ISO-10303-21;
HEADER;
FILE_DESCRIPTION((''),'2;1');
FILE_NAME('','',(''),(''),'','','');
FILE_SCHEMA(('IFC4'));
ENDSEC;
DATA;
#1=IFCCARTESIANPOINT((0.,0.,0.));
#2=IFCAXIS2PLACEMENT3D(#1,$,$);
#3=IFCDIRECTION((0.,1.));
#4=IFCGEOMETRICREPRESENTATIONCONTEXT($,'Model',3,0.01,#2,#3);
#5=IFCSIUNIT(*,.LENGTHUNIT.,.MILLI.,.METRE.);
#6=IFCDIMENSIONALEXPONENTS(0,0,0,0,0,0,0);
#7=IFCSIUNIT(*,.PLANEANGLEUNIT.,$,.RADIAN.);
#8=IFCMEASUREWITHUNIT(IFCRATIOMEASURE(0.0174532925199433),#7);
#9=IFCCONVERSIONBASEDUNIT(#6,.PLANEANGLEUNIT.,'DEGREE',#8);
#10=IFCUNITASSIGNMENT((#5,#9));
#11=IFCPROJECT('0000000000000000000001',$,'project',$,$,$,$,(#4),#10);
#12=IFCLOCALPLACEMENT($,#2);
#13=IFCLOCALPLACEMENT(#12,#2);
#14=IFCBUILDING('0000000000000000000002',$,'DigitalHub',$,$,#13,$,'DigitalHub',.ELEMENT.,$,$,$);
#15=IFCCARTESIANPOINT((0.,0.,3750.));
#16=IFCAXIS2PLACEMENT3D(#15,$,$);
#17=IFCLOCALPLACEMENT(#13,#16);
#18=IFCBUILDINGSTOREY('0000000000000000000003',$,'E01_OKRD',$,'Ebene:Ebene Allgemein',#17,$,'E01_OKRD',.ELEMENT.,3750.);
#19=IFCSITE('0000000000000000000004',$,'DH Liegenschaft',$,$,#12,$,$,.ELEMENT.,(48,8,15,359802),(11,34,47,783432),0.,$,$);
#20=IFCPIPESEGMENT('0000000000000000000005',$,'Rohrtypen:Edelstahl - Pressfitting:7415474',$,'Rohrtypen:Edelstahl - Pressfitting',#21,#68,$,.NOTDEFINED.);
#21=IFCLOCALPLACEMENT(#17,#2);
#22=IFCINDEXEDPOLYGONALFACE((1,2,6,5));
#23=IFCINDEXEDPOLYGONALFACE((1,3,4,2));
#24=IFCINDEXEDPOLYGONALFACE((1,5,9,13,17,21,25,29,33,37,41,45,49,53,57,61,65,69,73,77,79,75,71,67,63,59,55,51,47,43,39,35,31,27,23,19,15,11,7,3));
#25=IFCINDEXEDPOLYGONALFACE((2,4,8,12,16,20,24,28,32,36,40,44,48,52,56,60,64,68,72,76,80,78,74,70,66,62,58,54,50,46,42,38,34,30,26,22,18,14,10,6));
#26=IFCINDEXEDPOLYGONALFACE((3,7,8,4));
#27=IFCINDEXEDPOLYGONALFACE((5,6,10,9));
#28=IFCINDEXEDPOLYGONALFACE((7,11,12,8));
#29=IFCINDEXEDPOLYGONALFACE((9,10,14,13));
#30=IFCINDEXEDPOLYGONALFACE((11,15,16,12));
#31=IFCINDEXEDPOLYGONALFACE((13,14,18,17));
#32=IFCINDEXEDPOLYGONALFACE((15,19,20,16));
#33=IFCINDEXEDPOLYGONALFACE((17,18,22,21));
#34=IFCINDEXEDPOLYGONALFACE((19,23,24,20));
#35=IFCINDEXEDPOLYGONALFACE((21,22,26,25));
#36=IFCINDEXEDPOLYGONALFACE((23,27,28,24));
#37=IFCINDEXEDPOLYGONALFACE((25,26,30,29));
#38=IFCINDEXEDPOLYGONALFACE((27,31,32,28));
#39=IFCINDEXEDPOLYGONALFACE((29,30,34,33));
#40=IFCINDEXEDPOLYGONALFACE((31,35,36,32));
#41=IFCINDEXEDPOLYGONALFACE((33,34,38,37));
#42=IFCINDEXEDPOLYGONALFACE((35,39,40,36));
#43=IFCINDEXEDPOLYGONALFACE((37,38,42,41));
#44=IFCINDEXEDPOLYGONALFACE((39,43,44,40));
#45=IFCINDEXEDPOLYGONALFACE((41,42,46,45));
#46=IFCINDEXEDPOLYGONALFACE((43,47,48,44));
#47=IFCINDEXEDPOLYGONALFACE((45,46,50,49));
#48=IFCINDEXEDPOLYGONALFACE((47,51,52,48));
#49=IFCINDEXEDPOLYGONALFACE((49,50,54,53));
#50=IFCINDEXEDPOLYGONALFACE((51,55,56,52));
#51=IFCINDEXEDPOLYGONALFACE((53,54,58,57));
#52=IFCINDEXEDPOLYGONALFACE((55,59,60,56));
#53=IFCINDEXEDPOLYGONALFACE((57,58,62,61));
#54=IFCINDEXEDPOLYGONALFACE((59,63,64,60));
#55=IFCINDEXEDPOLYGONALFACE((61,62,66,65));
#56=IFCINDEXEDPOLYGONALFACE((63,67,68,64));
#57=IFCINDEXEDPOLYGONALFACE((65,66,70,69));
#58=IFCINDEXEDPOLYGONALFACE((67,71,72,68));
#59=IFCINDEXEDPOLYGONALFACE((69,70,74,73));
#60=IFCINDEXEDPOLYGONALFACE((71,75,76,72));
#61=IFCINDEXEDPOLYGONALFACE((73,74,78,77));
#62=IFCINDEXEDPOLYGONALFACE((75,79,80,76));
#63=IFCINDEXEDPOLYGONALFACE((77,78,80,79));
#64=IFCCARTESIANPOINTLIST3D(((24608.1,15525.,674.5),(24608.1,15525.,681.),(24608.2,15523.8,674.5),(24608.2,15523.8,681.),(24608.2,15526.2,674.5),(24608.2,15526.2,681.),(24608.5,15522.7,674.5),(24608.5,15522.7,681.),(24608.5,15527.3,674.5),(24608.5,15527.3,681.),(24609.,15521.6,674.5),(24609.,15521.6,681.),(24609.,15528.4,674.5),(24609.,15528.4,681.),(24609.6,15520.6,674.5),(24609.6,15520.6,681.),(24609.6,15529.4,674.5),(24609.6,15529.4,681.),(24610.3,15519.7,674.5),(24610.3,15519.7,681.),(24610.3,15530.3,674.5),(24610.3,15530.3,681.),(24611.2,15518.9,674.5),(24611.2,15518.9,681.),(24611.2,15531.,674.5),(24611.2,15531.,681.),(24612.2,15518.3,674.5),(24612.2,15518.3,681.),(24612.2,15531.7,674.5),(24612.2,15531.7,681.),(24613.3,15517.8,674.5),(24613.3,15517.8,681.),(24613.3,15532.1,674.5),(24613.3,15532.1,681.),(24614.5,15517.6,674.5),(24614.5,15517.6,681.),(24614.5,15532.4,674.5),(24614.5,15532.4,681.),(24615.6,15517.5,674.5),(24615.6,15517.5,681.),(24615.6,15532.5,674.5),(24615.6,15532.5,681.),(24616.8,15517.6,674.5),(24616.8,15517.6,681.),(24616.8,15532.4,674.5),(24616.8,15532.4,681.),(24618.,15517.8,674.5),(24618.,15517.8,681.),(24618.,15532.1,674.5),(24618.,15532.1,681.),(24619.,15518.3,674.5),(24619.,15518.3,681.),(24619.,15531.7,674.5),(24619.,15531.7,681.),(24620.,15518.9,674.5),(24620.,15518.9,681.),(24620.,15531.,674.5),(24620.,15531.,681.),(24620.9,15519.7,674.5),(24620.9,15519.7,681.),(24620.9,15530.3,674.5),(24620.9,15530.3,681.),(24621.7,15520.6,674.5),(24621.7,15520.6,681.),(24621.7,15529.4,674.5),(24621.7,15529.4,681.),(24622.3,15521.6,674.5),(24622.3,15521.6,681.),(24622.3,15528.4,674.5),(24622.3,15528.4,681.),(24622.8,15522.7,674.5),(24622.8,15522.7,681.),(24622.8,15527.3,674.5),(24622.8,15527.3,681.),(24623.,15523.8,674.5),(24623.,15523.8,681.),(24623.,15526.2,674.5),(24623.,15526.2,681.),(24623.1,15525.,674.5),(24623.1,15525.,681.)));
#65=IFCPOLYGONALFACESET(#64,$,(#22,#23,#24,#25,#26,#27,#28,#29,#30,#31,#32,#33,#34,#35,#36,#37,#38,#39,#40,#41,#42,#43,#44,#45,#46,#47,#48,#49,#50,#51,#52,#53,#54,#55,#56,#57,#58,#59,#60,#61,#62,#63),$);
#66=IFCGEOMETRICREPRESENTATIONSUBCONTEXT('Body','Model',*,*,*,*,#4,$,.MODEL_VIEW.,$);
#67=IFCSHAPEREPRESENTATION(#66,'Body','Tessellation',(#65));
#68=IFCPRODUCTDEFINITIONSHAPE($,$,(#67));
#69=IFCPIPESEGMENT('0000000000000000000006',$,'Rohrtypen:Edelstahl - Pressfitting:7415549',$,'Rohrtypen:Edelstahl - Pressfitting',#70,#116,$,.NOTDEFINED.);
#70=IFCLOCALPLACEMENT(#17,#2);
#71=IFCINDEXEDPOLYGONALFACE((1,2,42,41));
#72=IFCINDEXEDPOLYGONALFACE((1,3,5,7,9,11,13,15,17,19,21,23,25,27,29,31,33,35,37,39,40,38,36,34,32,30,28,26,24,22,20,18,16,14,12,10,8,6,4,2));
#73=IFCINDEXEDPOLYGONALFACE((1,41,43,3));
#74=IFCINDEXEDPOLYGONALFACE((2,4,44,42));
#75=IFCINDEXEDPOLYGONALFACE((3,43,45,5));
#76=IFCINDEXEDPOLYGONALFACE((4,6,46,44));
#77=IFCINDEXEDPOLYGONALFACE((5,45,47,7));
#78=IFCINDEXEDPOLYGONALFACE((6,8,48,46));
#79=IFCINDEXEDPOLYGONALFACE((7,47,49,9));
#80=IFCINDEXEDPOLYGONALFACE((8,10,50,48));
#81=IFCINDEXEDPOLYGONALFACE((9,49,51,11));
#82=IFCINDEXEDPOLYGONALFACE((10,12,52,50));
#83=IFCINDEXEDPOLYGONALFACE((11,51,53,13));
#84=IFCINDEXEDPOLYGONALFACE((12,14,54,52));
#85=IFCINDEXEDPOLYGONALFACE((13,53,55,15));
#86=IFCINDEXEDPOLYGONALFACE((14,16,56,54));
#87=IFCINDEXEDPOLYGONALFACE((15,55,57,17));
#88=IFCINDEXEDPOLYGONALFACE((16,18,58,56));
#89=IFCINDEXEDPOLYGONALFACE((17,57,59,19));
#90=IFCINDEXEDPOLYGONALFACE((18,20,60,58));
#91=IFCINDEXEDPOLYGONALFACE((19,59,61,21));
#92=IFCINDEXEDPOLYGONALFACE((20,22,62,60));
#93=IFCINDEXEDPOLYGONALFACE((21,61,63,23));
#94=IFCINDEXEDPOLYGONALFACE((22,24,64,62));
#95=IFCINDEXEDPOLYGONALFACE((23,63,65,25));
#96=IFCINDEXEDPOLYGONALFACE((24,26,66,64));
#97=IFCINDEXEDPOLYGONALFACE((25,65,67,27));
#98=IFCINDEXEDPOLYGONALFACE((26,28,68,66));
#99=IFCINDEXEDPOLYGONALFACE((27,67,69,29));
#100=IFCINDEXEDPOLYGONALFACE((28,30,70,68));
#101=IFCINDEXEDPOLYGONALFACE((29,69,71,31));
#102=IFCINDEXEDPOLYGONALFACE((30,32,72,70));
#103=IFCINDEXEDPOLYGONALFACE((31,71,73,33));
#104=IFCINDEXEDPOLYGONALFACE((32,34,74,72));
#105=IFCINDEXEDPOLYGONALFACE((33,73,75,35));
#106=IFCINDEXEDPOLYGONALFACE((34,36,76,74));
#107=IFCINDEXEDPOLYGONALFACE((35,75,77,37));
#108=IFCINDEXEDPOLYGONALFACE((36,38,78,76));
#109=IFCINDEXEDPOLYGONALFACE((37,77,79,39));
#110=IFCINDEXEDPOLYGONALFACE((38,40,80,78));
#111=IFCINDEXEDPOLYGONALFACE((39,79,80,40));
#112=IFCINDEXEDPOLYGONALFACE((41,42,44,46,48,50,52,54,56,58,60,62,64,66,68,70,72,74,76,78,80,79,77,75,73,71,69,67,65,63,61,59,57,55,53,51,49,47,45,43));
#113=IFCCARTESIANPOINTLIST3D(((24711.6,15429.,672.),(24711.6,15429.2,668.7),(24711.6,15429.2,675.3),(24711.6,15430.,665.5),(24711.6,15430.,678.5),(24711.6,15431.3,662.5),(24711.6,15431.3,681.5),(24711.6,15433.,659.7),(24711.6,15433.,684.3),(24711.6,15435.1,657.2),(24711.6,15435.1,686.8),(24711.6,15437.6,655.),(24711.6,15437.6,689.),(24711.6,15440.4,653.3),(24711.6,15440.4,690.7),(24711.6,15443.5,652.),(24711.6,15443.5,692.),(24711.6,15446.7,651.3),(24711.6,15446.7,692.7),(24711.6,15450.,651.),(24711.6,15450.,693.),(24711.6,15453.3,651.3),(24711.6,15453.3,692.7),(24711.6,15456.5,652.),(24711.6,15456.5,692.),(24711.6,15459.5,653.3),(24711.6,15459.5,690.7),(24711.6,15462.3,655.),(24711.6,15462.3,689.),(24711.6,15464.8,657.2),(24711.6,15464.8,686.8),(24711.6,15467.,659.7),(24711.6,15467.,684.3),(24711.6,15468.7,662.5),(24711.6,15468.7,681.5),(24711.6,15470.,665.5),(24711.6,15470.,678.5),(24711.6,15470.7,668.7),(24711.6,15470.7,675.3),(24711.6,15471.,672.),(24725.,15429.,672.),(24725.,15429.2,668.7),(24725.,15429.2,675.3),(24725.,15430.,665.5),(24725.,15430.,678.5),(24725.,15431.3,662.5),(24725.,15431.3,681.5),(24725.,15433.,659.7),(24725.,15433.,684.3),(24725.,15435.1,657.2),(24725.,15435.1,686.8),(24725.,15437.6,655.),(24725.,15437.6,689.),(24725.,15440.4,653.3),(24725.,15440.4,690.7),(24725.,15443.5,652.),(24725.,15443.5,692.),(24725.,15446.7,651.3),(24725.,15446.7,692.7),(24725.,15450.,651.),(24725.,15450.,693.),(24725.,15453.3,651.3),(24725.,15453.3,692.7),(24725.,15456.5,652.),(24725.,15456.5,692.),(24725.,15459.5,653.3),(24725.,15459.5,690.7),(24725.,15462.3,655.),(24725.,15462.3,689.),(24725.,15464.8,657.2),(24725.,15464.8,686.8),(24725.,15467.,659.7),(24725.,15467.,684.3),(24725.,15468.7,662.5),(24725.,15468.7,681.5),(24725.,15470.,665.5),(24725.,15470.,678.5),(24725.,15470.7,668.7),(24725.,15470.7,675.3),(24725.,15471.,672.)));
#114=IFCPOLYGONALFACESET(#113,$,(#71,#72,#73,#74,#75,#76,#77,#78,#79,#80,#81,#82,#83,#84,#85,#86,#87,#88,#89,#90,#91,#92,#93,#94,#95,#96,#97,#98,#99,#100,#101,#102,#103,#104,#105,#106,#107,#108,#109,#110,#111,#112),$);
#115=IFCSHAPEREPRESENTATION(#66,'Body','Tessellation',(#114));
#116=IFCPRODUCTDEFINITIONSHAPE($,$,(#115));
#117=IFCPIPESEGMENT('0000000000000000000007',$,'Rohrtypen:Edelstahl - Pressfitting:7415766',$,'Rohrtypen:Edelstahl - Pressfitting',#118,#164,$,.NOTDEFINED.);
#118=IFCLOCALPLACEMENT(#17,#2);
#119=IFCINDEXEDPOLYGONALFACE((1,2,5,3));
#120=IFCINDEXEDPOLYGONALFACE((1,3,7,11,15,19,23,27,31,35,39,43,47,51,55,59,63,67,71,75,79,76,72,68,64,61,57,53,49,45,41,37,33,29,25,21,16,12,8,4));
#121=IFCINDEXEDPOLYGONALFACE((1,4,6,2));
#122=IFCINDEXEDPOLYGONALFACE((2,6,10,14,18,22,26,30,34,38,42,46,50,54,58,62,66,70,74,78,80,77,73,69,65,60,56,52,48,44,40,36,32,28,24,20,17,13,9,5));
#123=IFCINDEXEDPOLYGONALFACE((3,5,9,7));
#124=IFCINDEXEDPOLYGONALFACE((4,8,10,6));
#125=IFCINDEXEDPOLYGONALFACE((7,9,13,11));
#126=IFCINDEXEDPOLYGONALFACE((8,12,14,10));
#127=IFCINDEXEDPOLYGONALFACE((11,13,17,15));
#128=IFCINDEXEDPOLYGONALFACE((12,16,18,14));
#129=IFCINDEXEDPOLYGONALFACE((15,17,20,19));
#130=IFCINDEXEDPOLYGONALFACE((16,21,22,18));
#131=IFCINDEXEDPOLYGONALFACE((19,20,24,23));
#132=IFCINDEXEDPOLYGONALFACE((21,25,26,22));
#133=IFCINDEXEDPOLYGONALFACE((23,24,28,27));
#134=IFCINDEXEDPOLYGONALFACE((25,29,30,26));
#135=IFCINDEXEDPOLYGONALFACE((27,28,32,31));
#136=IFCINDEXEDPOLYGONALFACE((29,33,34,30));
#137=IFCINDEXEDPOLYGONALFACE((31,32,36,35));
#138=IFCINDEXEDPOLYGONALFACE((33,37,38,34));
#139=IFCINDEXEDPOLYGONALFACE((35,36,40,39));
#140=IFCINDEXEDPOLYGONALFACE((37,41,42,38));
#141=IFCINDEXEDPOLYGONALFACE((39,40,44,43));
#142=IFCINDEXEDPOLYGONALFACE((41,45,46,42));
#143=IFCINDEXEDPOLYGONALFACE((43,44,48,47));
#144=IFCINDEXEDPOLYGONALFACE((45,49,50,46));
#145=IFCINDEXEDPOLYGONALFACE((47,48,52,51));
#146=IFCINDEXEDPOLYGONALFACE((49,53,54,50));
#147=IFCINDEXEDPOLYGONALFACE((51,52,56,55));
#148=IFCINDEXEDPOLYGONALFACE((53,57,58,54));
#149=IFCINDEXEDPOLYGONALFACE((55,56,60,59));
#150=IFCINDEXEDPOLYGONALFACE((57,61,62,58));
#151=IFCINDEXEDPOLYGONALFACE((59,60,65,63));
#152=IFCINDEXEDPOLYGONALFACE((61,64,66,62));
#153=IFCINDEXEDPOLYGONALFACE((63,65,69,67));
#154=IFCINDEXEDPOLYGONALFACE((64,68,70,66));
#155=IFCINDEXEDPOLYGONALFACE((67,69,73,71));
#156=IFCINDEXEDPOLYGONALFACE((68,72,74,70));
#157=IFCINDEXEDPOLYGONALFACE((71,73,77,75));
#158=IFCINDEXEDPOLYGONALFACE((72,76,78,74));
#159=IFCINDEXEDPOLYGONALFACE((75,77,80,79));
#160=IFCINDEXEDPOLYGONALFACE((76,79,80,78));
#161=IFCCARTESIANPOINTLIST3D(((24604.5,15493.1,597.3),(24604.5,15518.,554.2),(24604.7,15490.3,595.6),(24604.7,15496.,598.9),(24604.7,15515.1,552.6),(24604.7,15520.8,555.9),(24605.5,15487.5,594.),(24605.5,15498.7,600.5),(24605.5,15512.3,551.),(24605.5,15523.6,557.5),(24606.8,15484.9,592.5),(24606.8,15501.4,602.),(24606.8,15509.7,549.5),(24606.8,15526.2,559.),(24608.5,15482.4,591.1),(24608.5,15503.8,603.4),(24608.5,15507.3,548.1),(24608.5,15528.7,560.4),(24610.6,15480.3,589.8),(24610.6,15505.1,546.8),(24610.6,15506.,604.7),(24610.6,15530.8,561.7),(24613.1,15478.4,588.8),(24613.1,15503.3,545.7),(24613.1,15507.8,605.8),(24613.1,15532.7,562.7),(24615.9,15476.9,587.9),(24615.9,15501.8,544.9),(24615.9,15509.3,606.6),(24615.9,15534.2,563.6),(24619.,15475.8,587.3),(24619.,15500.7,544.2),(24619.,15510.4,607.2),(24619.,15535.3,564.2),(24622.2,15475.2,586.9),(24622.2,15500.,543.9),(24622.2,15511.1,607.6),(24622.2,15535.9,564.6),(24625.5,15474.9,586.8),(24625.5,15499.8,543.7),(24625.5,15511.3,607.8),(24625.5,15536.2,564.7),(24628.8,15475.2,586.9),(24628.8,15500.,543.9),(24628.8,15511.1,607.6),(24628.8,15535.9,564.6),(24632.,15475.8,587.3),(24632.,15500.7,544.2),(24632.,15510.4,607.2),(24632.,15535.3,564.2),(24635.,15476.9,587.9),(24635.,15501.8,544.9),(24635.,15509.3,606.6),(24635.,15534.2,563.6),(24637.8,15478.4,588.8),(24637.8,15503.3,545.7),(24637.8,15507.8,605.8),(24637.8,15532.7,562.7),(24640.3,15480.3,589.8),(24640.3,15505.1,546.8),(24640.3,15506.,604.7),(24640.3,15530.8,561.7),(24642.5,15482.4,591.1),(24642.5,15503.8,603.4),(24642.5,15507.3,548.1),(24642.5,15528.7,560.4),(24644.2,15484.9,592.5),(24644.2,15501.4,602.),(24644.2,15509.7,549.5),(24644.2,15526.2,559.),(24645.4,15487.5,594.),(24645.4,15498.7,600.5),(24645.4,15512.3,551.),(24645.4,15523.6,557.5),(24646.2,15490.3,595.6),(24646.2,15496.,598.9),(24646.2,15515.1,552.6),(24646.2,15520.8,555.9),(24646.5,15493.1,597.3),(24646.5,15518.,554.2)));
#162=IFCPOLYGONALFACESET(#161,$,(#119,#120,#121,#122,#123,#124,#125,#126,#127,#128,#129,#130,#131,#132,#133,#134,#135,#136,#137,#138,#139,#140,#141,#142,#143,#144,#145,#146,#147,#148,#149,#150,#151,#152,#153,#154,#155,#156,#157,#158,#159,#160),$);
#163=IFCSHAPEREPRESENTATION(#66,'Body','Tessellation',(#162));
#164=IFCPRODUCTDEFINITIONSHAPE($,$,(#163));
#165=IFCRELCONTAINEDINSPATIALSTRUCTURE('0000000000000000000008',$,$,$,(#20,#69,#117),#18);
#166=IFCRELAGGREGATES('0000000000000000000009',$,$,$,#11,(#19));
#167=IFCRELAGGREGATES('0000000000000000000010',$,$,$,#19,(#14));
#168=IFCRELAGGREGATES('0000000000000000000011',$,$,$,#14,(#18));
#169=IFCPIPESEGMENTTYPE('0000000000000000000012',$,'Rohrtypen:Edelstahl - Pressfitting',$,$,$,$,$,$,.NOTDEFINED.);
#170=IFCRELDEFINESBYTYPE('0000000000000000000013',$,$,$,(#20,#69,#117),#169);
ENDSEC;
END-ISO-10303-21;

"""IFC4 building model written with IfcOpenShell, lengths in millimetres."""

from ifc_helpers import new_model, entity, si_unit, converted_unit, direction, frame, origin, place, context, subcontext, project, spatial, indexed_curve, outline, extrude, type_object, element, save


model = new_model("IFC4")

# Units and contexts
model_context = context("Model", 3, precision=0.01, world=origin(), true_north=direction((0.0, 1.0)))
body_context = subcontext(model_context, "Body", "Model", "MODEL_VIEW")
ifc_project = project(units=[si_unit("LENGTHUNIT", "METRE", prefix="MILLI"), converted_unit("PLANEANGLEUNIT", "DEGREE", entity("IfcRatioMeasure", 0.0174532925199433), si_unit("PLANEANGLEUNIT", "RADIAN"), dimensions=[0, 0, 0, 0, 0, 0, 0])], contexts=[model_context])

# Site, building, storey
site_placement = place(None, origin())
site = spatial("IfcSite", under=ifc_project, at=site_placement, Name="DH Liegenschaft", CompositionType="ELEMENT", RefLatitude=(48, 8, 15, 359802), RefLongitude=(11, 34, 47, 783432), RefElevation=0.0)
building_placement = place(site_placement, origin())
building = spatial("IfcBuilding", under=site, at=building_placement, Name="DigitalHub", LongName="DigitalHub", CompositionType="ELEMENT")
storey_placement = place(building_placement, frame((0.0, 0.0, 3750.0)))
storey = spatial("IfcBuildingStorey", under=building, at=storey_placement, Name="E01_OKRD", ObjectType="Ebene:Ebene Allgemein", LongName="E01_OKRD", CompositionType="ELEMENT", Elevation=3750.0)

# Pipe segments
pipe_segment_type_1 = type_object("IfcPipeSegmentType", Name="Rohrtypen:Edelstahl - Pressfitting", PredefinedType="NOTDEFINED")
pipe_segment_1_placement = place(storey_placement, frame((24606.5, 15515.9, 674.5)))
element("IfcPipeSegment", 1, at=pipe_segment_1_placement, inside=storey, type_object=pipe_segment_type_1, Name="Rohrtypen:Edelstahl - Pressfitting:7415474", ObjectType="Rohrtypen:Edelstahl - Pressfitting", PredefinedType="NOTDEFINED", context=body_context, shape_type="SweptSolid", body=[
    extrude(outline(indexed_curve([(7.5, 0.0), (7.4, 1.2), (7.1, 2.3), (6.7, 3.4), (6.1, 4.4), (5.3, 5.3), (4.4, 6.1), (3.4, 6.7), (2.3, 7.1), (1.2, 7.4), (0.0, 7.5), (-1.2, 7.4), (-2.3, 7.1), (-3.4, 6.7), (-4.4, 6.1), (-5.3, 5.3), (-6.1, 4.4), (-6.7, 3.4), (-7.1, 2.3), (-7.4, 1.2), (-7.5, 0.0), (-7.4, -1.2), (-7.1, -2.3), (-6.7, -3.4), (-6.1, -4.4), (-5.3, -5.3), (-4.4, -6.1), (-3.4, -6.7), (-2.3, -7.1), (-1.2, -7.4), (0.0, -7.5), (1.2, -7.4), (2.3, -7.1), (3.4, -6.7), (4.4, -6.1), (5.3, -5.3), (6.1, -4.4), (6.7, -3.4), (7.1, -2.3), (7.4, -1.2), (7.5, 0.0)], self_intersect=False)), frame((9.1, 9.1, 0.0)), (0.0, 0.0, 1.0), 6.5),
])
pipe_segment_2_placement = place(storey_placement, frame((24711.6, 15427.4, 649.4)))
element("IfcPipeSegment", 2, at=pipe_segment_2_placement, inside=storey, type_object=pipe_segment_type_1, Name="Rohrtypen:Edelstahl - Pressfitting:7415549", ObjectType="Rohrtypen:Edelstahl - Pressfitting", PredefinedType="NOTDEFINED", context=body_context, shape_type="SweptSolid", body=[
    extrude(outline(indexed_curve([(21.0, 0.0), (20.7, 3.3), (20.0, 6.5), (18.7, 9.5), (17.0, 12.3), (14.8, 14.8), (12.3, 17.0), (9.5, 18.7), (6.5, 20.0), (3.3, 20.7), (0.0, 21.0), (-3.3, 20.7), (-6.5, 20.0), (-9.5, 18.7), (-12.3, 17.0), (-14.8, 14.8), (-17.0, 12.3), (-18.7, 9.5), (-20.0, 6.5), (-20.7, 3.3), (-21.0, 0.0), (-20.7, -3.3), (-20.0, -6.5), (-18.7, -9.5), (-17.0, -12.3), (-14.8, -14.8), (-12.3, -17.0), (-9.5, -18.7), (-6.5, -20.0), (-3.3, -20.7), (0.0, -21.0), (3.3, -20.7), (6.5, -20.0), (9.5, -18.7), (12.3, -17.0), (14.8, -14.8), (17.0, -12.3), (18.7, -9.5), (20.0, -6.5), (20.7, -3.3), (21.0, 0.0)], self_intersect=False)), frame((0.0, 22.6, 22.6), z_axis=(1.0, 0.0, 0.0), x_axis=(0.0, 1.0, 0.0)), (0.0, 0.0, 1.0), 13.3),
])
pipe_segment_3_placement = place(storey_placement, frame((24602.9, 15473.3, 542.1)))
element("IfcPipeSegment", 3, at=pipe_segment_3_placement, inside=storey, type_object=pipe_segment_type_1, Name="Rohrtypen:Edelstahl - Pressfitting:7415766", ObjectType="Rohrtypen:Edelstahl - Pressfitting", PredefinedType="NOTDEFINED", context=body_context, shape_type="SweptSolid", body=[
    extrude(outline(indexed_curve([(21.0, 0.0), (20.7, 3.3), (20.0, 6.5), (18.7, 9.5), (17.0, 12.3), (14.8, 14.8), (12.3, 17.0), (9.5, 18.7), (6.5, 20.0), (3.3, 20.7), (0.0, 21.0), (-3.3, 20.7), (-6.5, 20.0), (-9.5, 18.7), (-12.3, 17.0), (-14.8, 14.8), (-17.0, 12.3), (-18.7, 9.5), (-20.0, 6.5), (-20.7, 3.3), (-21.0, 0.0), (-20.7, -3.3), (-20.0, -6.5), (-18.7, -9.5), (-17.0, -12.3), (-14.8, -14.8), (-12.3, -17.0), (-9.5, -18.7), (-6.5, -20.0), (-3.3, -20.7), (0.0, -21.0), (3.3, -20.7), (6.5, -20.0), (9.5, -18.7), (12.3, -17.0), (14.8, -14.8), (17.0, -12.3), (18.7, -9.5), (20.0, -6.5), (20.7, -3.3), (21.0, 0.0)], self_intersect=False)), frame((22.6, 44.6, 12.1), z_axis=(0.0, -0.5, 0.866025), x_axis=(1.0, 0.0, 0.0)), (0.0, 0.0, 1.0), 49.7),
])

save(model, "model.ifc")
